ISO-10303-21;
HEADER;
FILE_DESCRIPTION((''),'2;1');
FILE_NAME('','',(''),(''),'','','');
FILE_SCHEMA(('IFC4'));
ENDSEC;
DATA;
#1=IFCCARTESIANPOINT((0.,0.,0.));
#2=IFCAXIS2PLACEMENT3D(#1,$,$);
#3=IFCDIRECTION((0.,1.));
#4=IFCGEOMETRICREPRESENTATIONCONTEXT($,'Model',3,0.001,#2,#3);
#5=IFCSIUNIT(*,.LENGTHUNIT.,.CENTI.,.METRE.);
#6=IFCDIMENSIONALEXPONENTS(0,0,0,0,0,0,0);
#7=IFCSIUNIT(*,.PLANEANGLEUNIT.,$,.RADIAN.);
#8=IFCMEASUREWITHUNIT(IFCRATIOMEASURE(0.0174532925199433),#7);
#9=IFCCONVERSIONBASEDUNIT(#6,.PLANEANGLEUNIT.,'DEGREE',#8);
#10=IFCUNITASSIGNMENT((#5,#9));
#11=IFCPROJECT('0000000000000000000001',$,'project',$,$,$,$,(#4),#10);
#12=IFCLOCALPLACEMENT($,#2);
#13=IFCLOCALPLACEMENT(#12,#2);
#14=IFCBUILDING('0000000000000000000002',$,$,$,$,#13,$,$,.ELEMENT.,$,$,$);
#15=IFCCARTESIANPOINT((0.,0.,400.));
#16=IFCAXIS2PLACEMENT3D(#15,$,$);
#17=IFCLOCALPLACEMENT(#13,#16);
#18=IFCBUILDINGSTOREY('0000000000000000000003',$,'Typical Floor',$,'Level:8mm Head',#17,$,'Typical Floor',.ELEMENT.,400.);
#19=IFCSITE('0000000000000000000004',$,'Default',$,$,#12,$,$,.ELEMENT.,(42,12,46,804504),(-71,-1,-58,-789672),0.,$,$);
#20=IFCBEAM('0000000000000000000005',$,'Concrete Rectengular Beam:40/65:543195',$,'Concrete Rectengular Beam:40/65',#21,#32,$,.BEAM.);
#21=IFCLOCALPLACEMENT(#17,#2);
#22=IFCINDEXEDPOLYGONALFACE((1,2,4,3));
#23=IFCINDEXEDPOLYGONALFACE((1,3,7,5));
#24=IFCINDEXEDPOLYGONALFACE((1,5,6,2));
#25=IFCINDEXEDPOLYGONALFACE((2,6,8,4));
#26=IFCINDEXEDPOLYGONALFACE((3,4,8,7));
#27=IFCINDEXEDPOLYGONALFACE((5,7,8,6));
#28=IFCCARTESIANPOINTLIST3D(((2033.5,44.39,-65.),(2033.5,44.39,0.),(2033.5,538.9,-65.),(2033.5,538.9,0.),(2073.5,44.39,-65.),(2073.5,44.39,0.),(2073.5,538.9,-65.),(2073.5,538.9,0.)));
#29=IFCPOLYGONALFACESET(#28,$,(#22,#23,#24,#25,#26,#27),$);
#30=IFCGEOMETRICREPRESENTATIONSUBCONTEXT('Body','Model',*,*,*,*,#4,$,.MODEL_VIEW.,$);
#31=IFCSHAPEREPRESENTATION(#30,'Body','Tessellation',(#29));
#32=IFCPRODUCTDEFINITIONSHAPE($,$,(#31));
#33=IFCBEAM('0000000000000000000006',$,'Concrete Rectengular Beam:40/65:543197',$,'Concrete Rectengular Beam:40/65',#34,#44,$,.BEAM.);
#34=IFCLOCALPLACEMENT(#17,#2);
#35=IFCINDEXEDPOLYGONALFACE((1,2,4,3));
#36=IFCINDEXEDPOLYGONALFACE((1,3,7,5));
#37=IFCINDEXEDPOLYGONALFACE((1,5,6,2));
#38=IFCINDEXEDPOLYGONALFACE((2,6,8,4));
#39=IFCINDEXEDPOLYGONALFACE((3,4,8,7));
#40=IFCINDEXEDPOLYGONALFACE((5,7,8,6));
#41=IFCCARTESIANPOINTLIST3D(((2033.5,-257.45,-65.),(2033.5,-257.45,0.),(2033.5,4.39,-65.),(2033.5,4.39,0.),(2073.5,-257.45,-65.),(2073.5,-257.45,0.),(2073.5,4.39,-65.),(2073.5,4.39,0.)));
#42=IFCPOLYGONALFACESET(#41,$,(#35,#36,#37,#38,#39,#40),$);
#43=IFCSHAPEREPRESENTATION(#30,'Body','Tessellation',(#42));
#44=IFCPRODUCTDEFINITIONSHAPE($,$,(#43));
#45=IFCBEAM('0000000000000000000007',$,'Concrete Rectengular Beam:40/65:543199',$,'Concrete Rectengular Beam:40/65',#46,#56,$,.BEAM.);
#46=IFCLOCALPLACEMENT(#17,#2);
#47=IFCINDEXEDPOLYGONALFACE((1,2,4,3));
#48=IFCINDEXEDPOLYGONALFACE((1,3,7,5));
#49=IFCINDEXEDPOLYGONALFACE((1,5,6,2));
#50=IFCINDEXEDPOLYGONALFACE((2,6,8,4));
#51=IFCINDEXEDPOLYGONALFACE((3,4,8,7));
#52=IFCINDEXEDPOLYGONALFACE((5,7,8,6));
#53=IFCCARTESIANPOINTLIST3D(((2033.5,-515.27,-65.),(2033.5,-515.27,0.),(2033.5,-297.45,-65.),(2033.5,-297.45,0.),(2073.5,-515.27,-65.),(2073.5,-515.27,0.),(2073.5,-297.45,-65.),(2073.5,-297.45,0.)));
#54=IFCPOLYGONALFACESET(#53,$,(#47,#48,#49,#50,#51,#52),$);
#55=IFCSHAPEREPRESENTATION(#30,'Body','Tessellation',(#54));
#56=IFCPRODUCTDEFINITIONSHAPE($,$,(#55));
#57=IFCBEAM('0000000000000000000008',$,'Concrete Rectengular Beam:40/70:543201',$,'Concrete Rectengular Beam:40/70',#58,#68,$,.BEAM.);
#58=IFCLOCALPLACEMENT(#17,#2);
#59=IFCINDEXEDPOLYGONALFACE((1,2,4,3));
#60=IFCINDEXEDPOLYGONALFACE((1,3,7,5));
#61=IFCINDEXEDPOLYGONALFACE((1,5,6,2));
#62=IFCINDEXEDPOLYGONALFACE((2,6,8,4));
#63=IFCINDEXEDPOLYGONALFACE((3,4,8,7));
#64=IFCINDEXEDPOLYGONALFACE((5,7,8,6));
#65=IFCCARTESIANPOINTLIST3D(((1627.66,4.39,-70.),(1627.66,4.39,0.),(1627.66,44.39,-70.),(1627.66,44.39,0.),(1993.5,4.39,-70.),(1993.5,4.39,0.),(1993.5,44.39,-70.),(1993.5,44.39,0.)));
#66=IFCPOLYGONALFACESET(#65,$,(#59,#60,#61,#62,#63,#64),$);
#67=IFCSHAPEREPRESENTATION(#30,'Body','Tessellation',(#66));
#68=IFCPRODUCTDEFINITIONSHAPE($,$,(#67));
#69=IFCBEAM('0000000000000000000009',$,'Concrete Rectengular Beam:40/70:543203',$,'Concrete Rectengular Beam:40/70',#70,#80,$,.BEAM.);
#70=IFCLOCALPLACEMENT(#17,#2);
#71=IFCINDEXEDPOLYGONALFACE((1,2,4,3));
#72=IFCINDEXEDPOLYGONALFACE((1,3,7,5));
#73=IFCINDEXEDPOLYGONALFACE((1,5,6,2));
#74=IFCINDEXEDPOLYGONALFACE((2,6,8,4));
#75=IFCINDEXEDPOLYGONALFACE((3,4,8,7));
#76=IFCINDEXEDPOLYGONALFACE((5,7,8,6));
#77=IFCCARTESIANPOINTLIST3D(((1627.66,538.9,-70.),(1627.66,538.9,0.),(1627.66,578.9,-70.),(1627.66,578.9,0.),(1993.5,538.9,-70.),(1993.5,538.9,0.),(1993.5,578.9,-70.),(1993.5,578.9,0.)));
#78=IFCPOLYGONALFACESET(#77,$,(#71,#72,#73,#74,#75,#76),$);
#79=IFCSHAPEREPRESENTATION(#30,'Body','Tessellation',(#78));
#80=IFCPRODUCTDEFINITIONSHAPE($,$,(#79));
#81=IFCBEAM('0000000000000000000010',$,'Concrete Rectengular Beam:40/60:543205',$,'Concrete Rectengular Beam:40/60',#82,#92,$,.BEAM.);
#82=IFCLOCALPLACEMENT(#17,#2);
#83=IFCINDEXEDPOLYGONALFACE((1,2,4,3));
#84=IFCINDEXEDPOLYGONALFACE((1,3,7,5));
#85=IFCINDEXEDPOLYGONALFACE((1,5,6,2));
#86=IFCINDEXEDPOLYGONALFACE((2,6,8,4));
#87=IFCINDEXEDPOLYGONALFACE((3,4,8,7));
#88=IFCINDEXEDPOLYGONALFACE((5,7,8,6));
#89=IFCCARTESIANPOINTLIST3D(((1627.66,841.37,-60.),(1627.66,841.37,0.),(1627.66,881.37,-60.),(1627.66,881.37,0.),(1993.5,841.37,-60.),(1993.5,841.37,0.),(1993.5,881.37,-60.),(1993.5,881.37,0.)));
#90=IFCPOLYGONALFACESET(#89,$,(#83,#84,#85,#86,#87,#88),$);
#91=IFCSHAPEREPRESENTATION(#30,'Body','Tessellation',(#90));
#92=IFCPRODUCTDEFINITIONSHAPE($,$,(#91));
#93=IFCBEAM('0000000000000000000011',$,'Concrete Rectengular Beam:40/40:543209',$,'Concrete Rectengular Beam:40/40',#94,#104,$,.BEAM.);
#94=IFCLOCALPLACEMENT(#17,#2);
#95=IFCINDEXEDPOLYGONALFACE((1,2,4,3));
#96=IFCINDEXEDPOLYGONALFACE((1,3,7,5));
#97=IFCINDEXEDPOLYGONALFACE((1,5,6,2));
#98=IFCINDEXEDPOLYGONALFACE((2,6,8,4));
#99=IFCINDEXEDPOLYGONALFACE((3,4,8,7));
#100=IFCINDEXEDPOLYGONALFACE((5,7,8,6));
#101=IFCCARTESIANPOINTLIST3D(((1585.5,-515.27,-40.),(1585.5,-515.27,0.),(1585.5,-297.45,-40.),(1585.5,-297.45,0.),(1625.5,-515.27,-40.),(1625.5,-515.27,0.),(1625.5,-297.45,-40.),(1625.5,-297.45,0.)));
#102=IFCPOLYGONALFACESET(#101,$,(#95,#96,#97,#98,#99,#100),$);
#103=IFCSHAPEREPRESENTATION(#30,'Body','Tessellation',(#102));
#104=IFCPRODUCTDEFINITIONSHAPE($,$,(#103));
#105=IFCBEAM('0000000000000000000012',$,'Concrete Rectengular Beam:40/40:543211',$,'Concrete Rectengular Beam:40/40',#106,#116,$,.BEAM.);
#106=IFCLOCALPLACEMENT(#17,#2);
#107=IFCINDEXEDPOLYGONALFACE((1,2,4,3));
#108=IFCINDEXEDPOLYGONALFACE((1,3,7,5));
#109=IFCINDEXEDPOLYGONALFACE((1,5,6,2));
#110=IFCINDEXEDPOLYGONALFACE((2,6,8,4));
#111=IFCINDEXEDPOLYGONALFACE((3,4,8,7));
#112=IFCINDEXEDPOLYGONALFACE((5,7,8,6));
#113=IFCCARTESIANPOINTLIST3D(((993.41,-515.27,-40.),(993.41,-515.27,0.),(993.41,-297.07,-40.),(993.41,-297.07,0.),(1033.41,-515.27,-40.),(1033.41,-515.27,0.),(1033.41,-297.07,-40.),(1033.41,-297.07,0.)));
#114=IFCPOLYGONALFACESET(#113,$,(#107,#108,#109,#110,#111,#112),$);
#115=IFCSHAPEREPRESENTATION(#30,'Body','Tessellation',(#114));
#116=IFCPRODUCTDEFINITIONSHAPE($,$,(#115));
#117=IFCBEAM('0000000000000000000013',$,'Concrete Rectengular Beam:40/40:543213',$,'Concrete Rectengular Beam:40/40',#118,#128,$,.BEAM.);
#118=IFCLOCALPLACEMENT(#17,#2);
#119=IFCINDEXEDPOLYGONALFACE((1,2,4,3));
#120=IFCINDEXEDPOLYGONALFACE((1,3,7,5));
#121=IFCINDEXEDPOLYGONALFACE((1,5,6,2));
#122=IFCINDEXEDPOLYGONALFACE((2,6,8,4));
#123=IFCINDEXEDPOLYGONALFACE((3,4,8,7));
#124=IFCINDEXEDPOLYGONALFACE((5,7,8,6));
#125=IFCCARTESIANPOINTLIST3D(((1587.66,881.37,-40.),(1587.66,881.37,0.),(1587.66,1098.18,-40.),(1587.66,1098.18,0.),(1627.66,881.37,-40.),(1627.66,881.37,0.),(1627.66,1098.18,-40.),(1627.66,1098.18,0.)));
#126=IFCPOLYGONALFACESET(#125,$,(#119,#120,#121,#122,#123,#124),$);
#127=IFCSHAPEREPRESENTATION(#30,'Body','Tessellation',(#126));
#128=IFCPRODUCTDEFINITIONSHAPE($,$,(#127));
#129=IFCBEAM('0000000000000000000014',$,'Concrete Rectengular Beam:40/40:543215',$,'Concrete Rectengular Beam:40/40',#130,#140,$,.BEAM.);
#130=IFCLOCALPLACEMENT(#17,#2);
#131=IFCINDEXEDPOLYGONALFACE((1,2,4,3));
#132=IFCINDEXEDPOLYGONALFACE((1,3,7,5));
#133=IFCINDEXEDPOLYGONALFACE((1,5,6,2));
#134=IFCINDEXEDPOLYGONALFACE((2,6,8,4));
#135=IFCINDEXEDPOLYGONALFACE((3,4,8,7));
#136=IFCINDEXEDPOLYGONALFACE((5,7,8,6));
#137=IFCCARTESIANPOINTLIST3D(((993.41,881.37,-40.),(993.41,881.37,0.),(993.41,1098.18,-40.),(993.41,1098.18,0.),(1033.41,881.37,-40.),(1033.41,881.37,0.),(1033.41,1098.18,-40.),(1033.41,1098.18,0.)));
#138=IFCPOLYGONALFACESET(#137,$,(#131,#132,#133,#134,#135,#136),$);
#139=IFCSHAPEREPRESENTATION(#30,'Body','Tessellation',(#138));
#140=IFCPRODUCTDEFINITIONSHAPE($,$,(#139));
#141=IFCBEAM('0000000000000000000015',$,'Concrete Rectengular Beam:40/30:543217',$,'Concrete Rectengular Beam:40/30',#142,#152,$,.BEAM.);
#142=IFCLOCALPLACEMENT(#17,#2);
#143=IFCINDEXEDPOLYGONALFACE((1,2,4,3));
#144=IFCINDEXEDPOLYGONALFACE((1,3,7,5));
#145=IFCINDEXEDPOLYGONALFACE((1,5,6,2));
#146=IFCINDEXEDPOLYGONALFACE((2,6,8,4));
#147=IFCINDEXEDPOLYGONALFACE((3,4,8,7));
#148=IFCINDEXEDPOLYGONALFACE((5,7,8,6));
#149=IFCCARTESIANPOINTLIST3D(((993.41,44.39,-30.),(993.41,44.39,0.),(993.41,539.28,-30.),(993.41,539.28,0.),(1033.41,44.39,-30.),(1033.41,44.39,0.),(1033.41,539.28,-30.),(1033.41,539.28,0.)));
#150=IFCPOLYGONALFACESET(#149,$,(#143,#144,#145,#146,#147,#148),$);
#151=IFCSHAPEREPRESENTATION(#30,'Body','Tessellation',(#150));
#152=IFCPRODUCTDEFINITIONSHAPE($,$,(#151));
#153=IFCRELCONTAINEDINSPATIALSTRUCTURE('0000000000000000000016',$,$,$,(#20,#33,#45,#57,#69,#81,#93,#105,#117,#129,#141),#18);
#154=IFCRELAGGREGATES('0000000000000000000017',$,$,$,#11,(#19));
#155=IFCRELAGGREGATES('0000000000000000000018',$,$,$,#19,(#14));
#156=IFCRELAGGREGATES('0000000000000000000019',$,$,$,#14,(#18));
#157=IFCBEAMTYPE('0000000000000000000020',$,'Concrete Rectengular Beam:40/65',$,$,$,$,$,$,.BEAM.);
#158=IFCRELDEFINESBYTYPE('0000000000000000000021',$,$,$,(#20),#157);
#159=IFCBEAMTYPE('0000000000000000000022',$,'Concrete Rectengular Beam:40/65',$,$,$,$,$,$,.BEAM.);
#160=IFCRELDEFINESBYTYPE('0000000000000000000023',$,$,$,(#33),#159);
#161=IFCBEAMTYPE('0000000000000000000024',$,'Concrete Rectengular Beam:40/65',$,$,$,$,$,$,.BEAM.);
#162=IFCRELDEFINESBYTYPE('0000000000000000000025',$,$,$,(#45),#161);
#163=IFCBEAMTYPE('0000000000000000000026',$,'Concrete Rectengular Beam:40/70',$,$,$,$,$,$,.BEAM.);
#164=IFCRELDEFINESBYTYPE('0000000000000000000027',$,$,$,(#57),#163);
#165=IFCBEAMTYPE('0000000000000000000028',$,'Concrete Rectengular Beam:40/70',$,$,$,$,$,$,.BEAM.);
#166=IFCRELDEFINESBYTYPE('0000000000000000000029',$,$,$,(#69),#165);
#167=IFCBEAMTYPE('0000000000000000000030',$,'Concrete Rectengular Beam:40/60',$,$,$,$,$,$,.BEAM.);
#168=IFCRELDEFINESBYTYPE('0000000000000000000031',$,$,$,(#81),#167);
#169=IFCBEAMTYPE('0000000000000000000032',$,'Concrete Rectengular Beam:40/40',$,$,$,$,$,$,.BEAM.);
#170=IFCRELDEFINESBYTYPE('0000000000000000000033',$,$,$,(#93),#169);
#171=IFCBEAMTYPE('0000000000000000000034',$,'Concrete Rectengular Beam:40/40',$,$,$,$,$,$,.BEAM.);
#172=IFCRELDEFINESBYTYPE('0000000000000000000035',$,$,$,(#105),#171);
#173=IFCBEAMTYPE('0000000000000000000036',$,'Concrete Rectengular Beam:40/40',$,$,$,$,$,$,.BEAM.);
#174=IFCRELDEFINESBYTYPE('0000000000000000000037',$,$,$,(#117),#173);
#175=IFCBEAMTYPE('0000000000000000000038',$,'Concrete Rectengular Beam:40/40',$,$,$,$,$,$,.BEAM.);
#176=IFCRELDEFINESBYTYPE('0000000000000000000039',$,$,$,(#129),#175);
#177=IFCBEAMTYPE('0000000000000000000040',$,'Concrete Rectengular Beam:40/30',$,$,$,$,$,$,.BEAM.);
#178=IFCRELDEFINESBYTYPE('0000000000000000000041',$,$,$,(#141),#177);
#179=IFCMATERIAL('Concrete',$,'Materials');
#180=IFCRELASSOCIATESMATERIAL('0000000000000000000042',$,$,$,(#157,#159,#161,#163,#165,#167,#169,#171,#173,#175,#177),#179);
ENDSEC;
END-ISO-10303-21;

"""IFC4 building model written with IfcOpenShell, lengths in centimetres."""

from ifc_helpers import new_model, entity, si_unit, converted_unit, direction, frame, origin, place, context, subcontext, project, spatial, indexed_curve, outline, extrude, source, transform, mapped, material, type_object, type_shapes, element, save


model = new_model("IFC4")

# Units and contexts
model_context = context("Model", 3, precision=0.001, world=origin(), true_north=direction((0.0, 1.0)))
body_context = subcontext(model_context, "Body", "Model", "MODEL_VIEW")
ifc_project = project(units=[si_unit("LENGTHUNIT", "METRE", prefix="CENTI"), converted_unit("PLANEANGLEUNIT", "DEGREE", entity("IfcRatioMeasure", 0.0174532925199433), si_unit("PLANEANGLEUNIT", "RADIAN"), dimensions=[0, 0, 0, 0, 0, 0, 0])], contexts=[model_context])

# Site, building, storey
site_placement = place(None, origin())
site = spatial("IfcSite", under=ifc_project, at=site_placement, Name="Default", CompositionType="ELEMENT", RefLatitude=(42, 12, 46, 804504), RefLongitude=(-71, -1, -58, -789672), RefElevation=0.0)
building_placement = place(site_placement, origin())
building = spatial("IfcBuilding", under=site, at=building_placement, CompositionType="ELEMENT")
storey_placement = place(building_placement, frame((0.0, 0.0, 400.0)))
storey = spatial("IfcBuildingStorey", under=building, at=storey_placement, Name="Typical Floor", ObjectType="Level:8mm Head", LongName="Typical Floor", CompositionType="ELEMENT", Elevation=400.0)

# Beams
ifc_material = material(Name="Concrete", Category="Materials")
beam_type_1 = type_object("IfcBeamType", Name="Concrete Rectengular Beam:40/65", PredefinedType="BEAM", material=ifc_material)
shared_shape_1 = source(origin(), body_context, "Body", "SweptSolid", [
    extrude(outline(indexed_curve([(-20.0, -32.5), (20.0, -32.5), (20.0, 32.5), (-20.0, 32.5), (-20.0, -32.5)], self_intersect=False)), frame((2053.5, 538.9, 367.5), z_axis=(0.0, -1.0, 0.0), x_axis=(-1.0, 0.0, 0.0)), (0.0, 0.0, 1.0), 494.51),
])
type_shapes(beam_type_1, [shared_shape_1])
beam_1_placement = place(storey_placement, frame((0.0, 0.0, -400.0)))
element("IfcBeam", 1, at=beam_1_placement, inside=storey, type_object=beam_type_1, Name="Concrete Rectengular Beam:40/65:543195", ObjectType="Concrete Rectengular Beam:40/65", PredefinedType="BEAM", context=body_context, shape_type="MappedRepresentation", body=[
    mapped(shared_shape_1, transform((0.0, 0.0, 0.0), scale=1.0)),
])
beam_type_2 = type_object("IfcBeamType", Name="Concrete Rectengular Beam:40/65", PredefinedType="BEAM", material=ifc_material)
shared_shape_2 = source(origin(), body_context, "Body", "SweptSolid", [
    extrude(outline(indexed_curve([(-20.0, -32.5), (20.0, -32.5), (20.0, 32.5), (-20.0, 32.5), (-20.0, -32.5)], self_intersect=False)), frame((2053.5, 4.39, 367.5), z_axis=(0.0, -1.0, 0.0), x_axis=(-1.0, 0.0, 0.0)), (0.0, 0.0, 1.0), 261.84),
])
type_shapes(beam_type_2, [shared_shape_2])
beam_2_placement = place(storey_placement, frame((0.0, 0.0, -400.0)))
element("IfcBeam", 2, at=beam_2_placement, inside=storey, type_object=beam_type_2, Name="Concrete Rectengular Beam:40/65:543197", ObjectType="Concrete Rectengular Beam:40/65", PredefinedType="BEAM", context=body_context, shape_type="MappedRepresentation", body=[
    mapped(shared_shape_2, transform((0.0, 0.0, 0.0), scale=1.0)),
])
beam_type_3 = type_object("IfcBeamType", Name="Concrete Rectengular Beam:40/65", PredefinedType="BEAM", material=ifc_material)
shared_shape_3 = source(origin(), body_context, "Body", "SweptSolid", [
    extrude(outline(indexed_curve([(-20.0, -32.5), (20.0, -32.5), (20.0, 32.5), (-20.0, 32.5), (-20.0, -32.5)], self_intersect=False)), frame((2053.5, -297.45, 367.5), z_axis=(0.0, -1.0, 0.0), x_axis=(-1.0, 0.0, 0.0)), (0.0, 0.0, 1.0), 217.82),
])
type_shapes(beam_type_3, [shared_shape_3])
beam_3_placement = place(storey_placement, frame((0.0, 0.0, -400.0)))
element("IfcBeam", 3, at=beam_3_placement, inside=storey, type_object=beam_type_3, Name="Concrete Rectengular Beam:40/65:543199", ObjectType="Concrete Rectengular Beam:40/65", PredefinedType="BEAM", context=body_context, shape_type="MappedRepresentation", body=[
    mapped(shared_shape_3, transform((0.0, 0.0, 0.0), scale=1.0)),
])
beam_type_4 = type_object("IfcBeamType", Name="Concrete Rectengular Beam:40/70", PredefinedType="BEAM", material=ifc_material)
shared_shape_4 = source(origin(), body_context, "Body", "SweptSolid", [
    extrude(outline(indexed_curve([(-35.0, -20.0), (35.0, -20.0), (35.0, 20.0), (-35.0, 20.0), (-35.0, -20.0)], self_intersect=False)), frame((1993.5, 24.39, 365.0), z_axis=(-1.0, 0.0, 0.0), x_axis=(0.0, 0.0, -1.0)), (0.0, 0.0, 1.0), 365.84),
])
type_shapes(beam_type_4, [shared_shape_4])
beam_4_placement = place(storey_placement, frame((0.0, 0.0, -400.0)))
element("IfcBeam", 4, at=beam_4_placement, inside=storey, type_object=beam_type_4, Name="Concrete Rectengular Beam:40/70:543201", ObjectType="Concrete Rectengular Beam:40/70", PredefinedType="BEAM", context=body_context, shape_type="MappedRepresentation", body=[
    mapped(shared_shape_4, transform((0.0, 0.0, 0.0), scale=1.0)),
])
beam_type_5 = type_object("IfcBeamType", Name="Concrete Rectengular Beam:40/70", PredefinedType="BEAM", material=ifc_material)
shared_shape_5 = source(origin(), body_context, "Body", "SweptSolid", [
    extrude(outline(indexed_curve([(-35.0, -20.0), (35.0, -20.0), (35.0, 20.0), (-35.0, 20.0), (-35.0, -20.0)], self_intersect=False)), frame((1993.5, 558.9, 365.0), z_axis=(-1.0, 0.0, 0.0), x_axis=(0.0, 0.0, -1.0)), (0.0, 0.0, 1.0), 365.84),
])
type_shapes(beam_type_5, [shared_shape_5])
beam_5_placement = place(storey_placement, frame((0.0, 0.0, -400.0)))
element("IfcBeam", 5, at=beam_5_placement, inside=storey, type_object=beam_type_5, Name="Concrete Rectengular Beam:40/70:543203", ObjectType="Concrete Rectengular Beam:40/70", PredefinedType="BEAM", context=body_context, shape_type="MappedRepresentation", body=[
    mapped(shared_shape_5, transform((0.0, 0.0, 0.0), scale=1.0)),
])
beam_type_6 = type_object("IfcBeamType", Name="Concrete Rectengular Beam:40/60", PredefinedType="BEAM", material=ifc_material)
shared_shape_6 = source(origin(), body_context, "Body", "SweptSolid", [
    extrude(outline(indexed_curve([(-30.0, -20.0), (30.0, -20.0), (30.0, 20.0), (-30.0, 20.0), (-30.0, -20.0)], self_intersect=False)), frame((1993.5, 861.37, 370.0), z_axis=(-1.0, 0.0, 0.0), x_axis=(0.0, 0.0, -1.0)), (0.0, 0.0, 1.0), 365.84),
])
type_shapes(beam_type_6, [shared_shape_6])
beam_6_placement = place(storey_placement, frame((0.0, 0.0, -400.0)))
element("IfcBeam", 6, at=beam_6_placement, inside=storey, type_object=beam_type_6, Name="Concrete Rectengular Beam:40/60:543205", ObjectType="Concrete Rectengular Beam:40/60", PredefinedType="BEAM", context=body_context, shape_type="MappedRepresentation", body=[
    mapped(shared_shape_6, transform((0.0, 0.0, 0.0), scale=1.0)),
])
beam_type_7 = type_object("IfcBeamType", Name="Concrete Rectengular Beam:40/40", PredefinedType="BEAM", material=ifc_material)
shared_shape_7 = source(origin(), body_context, "Body", "SweptSolid", [
    extrude(outline(indexed_curve([(-20.0, -20.0), (20.0, -20.0), (20.0, 20.0), (-20.0, 20.0), (-20.0, -20.0)], self_intersect=False)), frame((1605.5, -515.27, 380.0), z_axis=(0.0, 1.0, 0.0), x_axis=(-1.0, 0.0, 0.0)), (0.0, 0.0, 1.0), 217.82),
])
type_shapes(beam_type_7, [shared_shape_7])
beam_7_placement = place(storey_placement, frame((0.0, 0.0, -400.0)))
element("IfcBeam", 7, at=beam_7_placement, inside=storey, type_object=beam_type_7, Name="Concrete Rectengular Beam:40/40:543209", ObjectType="Concrete Rectengular Beam:40/40", PredefinedType="BEAM", context=body_context, shape_type="MappedRepresentation", body=[
    mapped(shared_shape_7, transform((0.0, 0.0, 0.0), scale=1.0)),
])
beam_type_8 = type_object("IfcBeamType", Name="Concrete Rectengular Beam:40/40", PredefinedType="BEAM", material=ifc_material)
shared_shape_8 = source(origin(), body_context, "Body", "SweptSolid", [
    extrude(outline(indexed_curve([(-20.0, -20.0), (20.0, -20.0), (20.0, 20.0), (-20.0, 20.0), (-20.0, -20.0)], self_intersect=False)), frame((1013.41, -515.27, 380.0), z_axis=(0.0, 1.0, 0.0), x_axis=(-1.0, 0.0, 0.0)), (0.0, 0.0, 1.0), 218.21),
])
type_shapes(beam_type_8, [shared_shape_8])
beam_8_placement = place(storey_placement, frame((0.0, 0.0, -400.0)))
element("IfcBeam", 8, at=beam_8_placement, inside=storey, type_object=beam_type_8, Name="Concrete Rectengular Beam:40/40:543211", ObjectType="Concrete Rectengular Beam:40/40", PredefinedType="BEAM", context=body_context, shape_type="MappedRepresentation", body=[
    mapped(shared_shape_8, transform((0.0, 0.0, 0.0), scale=1.0)),
])
beam_type_9 = type_object("IfcBeamType", Name="Concrete Rectengular Beam:40/40", PredefinedType="BEAM", material=ifc_material)
shared_shape_9 = source(origin(), body_context, "Body", "SweptSolid", [
    extrude(outline(indexed_curve([(-20.0, -20.0), (20.0, -20.0), (20.0, 20.0), (-20.0, 20.0), (-20.0, -20.0)], self_intersect=False)), frame((1607.66, 1098.18, 380.0), z_axis=(0.0, -1.0, 0.0), x_axis=(-1.0, 0.0, 0.0)), (0.0, 0.0, 1.0), 216.81),
])
type_shapes(beam_type_9, [shared_shape_9])
beam_9_placement = place(storey_placement, frame((0.0, 0.0, -400.0)))
element("IfcBeam", 9, at=beam_9_placement, inside=storey, type_object=beam_type_9, Name="Concrete Rectengular Beam:40/40:543213", ObjectType="Concrete Rectengular Beam:40/40", PredefinedType="BEAM", context=body_context, shape_type="MappedRepresentation", body=[
    mapped(shared_shape_9, transform((0.0, 0.0, 0.0), scale=1.0)),
])
beam_type_10 = type_object("IfcBeamType", Name="Concrete Rectengular Beam:40/40", PredefinedType="BEAM", material=ifc_material)
shared_shape_10 = source(origin(), body_context, "Body", "SweptSolid", [
    extrude(outline(indexed_curve([(-20.0, -20.0), (20.0, -20.0), (20.0, 20.0), (-20.0, 20.0), (-20.0, -20.0)], self_intersect=False)), frame((1013.41, 1098.18, 380.0), z_axis=(0.0, -1.0, 0.0), x_axis=(-1.0, 0.0, 0.0)), (0.0, 0.0, 1.0), 216.81),
])
type_shapes(beam_type_10, [shared_shape_10])
beam_10_placement = place(storey_placement, frame((0.0, 0.0, -400.0)))
element("IfcBeam", 10, at=beam_10_placement, inside=storey, type_object=beam_type_10, Name="Concrete Rectengular Beam:40/40:543215", ObjectType="Concrete Rectengular Beam:40/40", PredefinedType="BEAM", context=body_context, shape_type="MappedRepresentation", body=[
    mapped(shared_shape_10, transform((0.0, 0.0, 0.0), scale=1.0)),
])
beam_type_11 = type_object("IfcBeamType", Name="Concrete Rectengular Beam:40/30", PredefinedType="BEAM", material=ifc_material)
shared_shape_11 = source(origin(), body_context, "Body", "SweptSolid", [
    extrude(outline(indexed_curve([(-20.0, -15.0), (20.0, -15.0), (20.0, 15.0), (-20.0, 15.0), (-20.0, -15.0)], self_intersect=False)), frame((1013.41, 539.28, 385.0), z_axis=(0.0, -1.0, 0.0), x_axis=(-1.0, 0.0, 0.0)), (0.0, 0.0, 1.0), 494.89),
])
type_shapes(beam_type_11, [shared_shape_11])
beam_11_placement = place(storey_placement, frame((0.0, 0.0, -400.0)))
element("IfcBeam", 11, at=beam_11_placement, inside=storey, type_object=beam_type_11, Name="Concrete Rectengular Beam:40/30:543217", ObjectType="Concrete Rectengular Beam:40/30", PredefinedType="BEAM", context=body_context, shape_type="MappedRepresentation", body=[
    mapped(shared_shape_11, transform((0.0, 0.0, 0.0), scale=1.0)),
])

save(model, "model.ifc")
